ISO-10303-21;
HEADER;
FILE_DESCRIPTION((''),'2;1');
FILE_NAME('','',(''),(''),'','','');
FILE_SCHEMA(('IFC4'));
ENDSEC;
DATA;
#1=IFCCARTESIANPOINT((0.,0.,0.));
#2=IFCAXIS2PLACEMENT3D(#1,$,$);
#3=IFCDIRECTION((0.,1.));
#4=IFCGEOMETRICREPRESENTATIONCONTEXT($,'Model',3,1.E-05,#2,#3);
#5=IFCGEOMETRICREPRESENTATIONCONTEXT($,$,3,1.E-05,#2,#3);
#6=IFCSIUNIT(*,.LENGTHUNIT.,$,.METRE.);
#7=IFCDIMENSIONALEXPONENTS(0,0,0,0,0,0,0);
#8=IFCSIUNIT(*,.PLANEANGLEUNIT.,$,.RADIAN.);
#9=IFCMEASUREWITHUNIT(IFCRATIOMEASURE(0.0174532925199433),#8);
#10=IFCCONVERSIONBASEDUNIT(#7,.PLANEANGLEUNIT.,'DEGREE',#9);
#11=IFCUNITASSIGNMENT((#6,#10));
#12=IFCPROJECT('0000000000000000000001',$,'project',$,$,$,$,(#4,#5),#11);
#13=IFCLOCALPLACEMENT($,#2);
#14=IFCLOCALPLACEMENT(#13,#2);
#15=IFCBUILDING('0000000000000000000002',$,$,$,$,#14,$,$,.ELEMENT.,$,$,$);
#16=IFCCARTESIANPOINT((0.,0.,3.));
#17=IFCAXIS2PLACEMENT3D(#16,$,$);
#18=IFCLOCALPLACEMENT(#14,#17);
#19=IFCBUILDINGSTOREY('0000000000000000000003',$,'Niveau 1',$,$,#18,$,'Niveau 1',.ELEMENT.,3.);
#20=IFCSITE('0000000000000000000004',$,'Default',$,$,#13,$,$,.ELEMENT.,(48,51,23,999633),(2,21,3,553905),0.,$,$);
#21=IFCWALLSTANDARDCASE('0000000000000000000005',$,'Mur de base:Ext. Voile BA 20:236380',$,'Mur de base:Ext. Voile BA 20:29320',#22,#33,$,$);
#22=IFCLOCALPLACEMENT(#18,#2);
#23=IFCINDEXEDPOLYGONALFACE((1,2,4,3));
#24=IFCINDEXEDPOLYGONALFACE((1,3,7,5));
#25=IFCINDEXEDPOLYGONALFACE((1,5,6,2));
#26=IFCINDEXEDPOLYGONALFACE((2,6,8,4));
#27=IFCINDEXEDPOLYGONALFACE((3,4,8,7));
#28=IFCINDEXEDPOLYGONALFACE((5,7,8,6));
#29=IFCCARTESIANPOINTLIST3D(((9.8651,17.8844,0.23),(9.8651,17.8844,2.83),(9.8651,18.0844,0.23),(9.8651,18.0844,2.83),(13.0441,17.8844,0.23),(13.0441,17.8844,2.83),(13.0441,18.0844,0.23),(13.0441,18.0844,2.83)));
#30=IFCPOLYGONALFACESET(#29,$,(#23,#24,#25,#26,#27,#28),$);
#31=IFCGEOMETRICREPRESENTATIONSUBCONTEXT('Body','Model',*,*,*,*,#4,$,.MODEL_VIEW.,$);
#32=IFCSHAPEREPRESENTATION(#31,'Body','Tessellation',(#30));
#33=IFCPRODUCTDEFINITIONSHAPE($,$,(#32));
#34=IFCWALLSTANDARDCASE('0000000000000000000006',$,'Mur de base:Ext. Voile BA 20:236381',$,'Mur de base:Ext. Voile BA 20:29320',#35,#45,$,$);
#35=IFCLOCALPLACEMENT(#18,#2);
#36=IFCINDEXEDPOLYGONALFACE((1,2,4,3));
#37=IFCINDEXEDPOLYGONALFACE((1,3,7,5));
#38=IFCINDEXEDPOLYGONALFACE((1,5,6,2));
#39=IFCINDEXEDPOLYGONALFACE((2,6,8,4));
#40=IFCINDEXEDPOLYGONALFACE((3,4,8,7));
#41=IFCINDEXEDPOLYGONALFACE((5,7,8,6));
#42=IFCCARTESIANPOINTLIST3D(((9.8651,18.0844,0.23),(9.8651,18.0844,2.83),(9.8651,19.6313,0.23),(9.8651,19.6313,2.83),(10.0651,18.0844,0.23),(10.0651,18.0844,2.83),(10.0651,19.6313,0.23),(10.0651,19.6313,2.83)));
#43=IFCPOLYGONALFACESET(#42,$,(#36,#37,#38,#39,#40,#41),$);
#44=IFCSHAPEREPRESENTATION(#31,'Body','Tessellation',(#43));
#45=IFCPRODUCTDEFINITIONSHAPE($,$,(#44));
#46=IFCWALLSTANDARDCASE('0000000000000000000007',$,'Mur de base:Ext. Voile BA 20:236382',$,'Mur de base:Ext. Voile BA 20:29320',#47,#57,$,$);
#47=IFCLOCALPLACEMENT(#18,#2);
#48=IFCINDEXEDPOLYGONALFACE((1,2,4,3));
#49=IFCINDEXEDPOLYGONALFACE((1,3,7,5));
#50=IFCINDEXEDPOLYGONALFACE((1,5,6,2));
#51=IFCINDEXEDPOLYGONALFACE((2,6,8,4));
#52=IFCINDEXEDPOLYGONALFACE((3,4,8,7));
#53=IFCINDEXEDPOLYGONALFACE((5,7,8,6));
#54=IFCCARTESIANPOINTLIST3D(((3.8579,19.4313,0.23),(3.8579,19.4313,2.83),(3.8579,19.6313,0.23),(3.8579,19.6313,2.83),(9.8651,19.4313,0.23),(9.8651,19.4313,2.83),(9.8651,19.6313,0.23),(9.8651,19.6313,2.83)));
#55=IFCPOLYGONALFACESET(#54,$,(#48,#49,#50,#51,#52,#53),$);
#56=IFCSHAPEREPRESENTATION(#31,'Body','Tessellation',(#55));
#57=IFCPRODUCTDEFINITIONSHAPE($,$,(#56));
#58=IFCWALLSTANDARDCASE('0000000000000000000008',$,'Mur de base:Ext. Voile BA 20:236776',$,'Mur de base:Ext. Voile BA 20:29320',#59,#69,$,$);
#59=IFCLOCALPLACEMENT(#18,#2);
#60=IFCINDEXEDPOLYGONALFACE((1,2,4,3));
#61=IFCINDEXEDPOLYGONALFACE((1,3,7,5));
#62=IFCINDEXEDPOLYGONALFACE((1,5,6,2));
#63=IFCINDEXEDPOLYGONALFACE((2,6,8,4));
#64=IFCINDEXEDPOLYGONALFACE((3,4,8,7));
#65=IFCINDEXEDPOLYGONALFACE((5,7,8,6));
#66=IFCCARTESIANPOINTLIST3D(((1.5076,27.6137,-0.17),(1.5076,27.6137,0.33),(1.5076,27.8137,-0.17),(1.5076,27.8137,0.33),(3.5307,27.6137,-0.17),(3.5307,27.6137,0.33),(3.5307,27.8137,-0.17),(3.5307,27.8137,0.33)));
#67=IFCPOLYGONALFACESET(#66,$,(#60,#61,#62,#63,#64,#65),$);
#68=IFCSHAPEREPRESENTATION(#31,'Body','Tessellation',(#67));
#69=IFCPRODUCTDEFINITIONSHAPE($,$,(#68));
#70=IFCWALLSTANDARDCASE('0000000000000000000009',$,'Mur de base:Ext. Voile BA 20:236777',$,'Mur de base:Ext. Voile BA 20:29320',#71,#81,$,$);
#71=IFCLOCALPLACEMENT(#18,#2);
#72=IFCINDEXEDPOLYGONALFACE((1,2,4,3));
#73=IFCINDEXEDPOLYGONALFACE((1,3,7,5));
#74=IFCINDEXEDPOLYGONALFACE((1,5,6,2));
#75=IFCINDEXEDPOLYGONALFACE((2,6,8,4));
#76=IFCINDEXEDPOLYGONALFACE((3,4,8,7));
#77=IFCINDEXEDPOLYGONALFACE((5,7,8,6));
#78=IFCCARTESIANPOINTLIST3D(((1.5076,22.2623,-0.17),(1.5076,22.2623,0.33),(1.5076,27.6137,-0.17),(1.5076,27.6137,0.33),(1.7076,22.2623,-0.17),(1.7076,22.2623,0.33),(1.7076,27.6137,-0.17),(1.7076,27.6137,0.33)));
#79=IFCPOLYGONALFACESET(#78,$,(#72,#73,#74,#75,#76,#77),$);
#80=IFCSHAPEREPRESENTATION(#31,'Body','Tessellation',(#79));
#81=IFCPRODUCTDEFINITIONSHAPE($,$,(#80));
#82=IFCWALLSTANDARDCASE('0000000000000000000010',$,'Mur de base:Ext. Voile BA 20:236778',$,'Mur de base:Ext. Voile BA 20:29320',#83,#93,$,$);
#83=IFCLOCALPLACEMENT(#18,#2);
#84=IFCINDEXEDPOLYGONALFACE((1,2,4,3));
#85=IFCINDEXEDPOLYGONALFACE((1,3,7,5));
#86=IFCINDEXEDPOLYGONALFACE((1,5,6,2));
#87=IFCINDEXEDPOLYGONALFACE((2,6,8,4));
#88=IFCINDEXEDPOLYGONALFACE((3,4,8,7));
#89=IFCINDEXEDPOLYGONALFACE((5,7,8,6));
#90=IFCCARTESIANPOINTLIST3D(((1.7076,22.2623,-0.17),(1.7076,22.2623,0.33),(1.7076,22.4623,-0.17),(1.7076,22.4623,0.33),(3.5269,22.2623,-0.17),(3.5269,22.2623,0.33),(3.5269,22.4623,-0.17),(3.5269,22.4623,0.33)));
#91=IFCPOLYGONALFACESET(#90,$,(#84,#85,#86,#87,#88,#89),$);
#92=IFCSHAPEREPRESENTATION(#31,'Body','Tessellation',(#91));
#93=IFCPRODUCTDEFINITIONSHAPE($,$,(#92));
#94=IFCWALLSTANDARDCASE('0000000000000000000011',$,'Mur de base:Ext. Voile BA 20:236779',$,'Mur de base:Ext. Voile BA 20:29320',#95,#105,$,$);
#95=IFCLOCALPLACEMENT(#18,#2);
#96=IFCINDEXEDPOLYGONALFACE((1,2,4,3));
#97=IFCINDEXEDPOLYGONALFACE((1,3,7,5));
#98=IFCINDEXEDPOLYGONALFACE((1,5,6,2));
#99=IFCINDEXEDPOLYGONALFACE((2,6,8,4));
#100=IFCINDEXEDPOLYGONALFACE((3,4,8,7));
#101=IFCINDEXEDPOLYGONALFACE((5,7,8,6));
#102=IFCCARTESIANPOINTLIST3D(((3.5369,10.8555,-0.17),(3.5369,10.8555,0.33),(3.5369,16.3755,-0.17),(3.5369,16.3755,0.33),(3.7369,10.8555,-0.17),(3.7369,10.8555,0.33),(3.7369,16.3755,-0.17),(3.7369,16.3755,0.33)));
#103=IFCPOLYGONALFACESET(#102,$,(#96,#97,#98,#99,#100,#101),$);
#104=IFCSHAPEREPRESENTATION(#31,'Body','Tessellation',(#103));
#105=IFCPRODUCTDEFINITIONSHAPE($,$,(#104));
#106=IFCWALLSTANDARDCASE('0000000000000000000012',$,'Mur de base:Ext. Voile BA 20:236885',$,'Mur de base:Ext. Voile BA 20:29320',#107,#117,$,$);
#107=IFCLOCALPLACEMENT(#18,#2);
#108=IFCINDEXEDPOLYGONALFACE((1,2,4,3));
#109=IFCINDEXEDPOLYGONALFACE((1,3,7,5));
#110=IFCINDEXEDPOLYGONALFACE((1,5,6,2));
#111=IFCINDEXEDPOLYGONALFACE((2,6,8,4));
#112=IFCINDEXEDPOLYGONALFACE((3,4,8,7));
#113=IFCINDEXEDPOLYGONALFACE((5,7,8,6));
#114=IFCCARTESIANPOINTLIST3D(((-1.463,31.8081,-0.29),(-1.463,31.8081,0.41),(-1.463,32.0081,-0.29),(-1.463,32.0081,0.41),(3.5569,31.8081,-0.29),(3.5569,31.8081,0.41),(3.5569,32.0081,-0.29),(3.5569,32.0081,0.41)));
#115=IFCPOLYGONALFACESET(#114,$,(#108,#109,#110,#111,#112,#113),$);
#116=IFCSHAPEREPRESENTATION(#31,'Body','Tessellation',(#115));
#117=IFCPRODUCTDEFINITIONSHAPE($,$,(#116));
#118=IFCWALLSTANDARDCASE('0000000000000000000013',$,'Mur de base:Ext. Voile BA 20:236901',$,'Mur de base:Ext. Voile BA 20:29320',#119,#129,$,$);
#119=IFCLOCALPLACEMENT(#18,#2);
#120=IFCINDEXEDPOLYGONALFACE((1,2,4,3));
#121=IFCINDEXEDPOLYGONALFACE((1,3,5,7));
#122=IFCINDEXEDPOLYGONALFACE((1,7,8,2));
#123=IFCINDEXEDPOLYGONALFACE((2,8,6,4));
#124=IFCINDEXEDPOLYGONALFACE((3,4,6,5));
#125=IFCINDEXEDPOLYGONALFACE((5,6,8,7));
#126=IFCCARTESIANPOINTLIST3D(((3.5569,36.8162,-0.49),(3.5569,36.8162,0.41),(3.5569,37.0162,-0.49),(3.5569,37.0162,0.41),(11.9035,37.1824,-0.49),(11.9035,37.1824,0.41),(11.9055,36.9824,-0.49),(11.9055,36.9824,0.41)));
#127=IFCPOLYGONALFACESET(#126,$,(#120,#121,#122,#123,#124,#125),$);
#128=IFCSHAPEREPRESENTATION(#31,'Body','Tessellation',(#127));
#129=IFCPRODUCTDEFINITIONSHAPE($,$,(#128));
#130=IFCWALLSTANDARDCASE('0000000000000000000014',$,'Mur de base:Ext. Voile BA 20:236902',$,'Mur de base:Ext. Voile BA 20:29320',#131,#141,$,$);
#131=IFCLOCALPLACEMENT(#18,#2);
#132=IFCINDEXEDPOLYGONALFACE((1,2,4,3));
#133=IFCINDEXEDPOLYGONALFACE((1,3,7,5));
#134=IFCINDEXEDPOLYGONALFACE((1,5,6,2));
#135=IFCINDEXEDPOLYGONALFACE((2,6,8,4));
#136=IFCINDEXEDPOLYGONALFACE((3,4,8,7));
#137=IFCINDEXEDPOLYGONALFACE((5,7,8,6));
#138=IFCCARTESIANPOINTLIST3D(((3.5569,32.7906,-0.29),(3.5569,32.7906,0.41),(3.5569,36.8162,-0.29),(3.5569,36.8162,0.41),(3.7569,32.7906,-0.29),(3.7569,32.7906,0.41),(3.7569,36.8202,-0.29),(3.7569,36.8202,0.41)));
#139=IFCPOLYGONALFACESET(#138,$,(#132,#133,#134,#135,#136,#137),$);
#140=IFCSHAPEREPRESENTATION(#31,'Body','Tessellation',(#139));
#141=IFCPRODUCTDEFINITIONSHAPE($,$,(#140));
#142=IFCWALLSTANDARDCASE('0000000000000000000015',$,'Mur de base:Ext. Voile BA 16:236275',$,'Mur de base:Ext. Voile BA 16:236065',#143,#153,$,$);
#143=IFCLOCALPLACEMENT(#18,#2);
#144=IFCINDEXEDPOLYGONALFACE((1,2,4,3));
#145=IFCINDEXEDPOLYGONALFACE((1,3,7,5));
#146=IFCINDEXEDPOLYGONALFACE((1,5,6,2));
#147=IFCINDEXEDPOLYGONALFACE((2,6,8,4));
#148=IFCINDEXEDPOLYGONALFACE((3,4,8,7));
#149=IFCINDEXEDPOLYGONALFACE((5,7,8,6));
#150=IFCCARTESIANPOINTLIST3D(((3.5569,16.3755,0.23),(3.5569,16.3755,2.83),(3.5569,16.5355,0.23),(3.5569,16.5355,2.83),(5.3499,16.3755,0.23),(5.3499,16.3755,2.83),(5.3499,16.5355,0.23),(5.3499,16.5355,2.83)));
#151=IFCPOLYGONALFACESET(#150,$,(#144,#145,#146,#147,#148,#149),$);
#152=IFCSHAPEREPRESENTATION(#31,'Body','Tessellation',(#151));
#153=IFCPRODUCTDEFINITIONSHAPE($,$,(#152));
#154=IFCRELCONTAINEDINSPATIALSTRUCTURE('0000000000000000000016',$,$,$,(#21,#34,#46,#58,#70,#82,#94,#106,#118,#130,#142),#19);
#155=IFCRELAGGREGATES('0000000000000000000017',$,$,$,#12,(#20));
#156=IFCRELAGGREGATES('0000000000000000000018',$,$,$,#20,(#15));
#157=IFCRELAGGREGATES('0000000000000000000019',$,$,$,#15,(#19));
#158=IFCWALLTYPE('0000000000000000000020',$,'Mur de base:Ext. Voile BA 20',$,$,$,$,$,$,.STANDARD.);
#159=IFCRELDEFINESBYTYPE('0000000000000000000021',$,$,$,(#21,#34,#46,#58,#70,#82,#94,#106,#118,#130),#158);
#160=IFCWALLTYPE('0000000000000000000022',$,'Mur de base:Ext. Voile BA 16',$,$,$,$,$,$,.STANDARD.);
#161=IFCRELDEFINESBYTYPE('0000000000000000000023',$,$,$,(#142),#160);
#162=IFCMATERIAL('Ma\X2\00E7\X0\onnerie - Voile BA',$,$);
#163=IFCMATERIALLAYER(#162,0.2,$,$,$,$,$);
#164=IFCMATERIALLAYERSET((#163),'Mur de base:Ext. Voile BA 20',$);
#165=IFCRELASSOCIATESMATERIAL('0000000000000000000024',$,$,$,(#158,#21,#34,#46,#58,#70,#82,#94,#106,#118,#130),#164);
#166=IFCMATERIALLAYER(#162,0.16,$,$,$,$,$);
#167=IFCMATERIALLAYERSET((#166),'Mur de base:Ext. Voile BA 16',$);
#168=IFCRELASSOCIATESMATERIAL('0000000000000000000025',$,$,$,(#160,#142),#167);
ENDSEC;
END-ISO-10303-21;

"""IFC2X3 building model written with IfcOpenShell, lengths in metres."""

from ifc_helpers import new_model, entity, si_unit, converted_unit, direction, frame, frame_2d, origin, place, context, subcontext, project, spatial, polyline, rectangle, outline, extrude, material, layer, layer_set, layer_usage, type_object, element, save


model = new_model("IFC2X3")

# Units and contexts
model_context = context("Model", 3, precision=1e-05, world=origin(), true_north=direction((0.0, 1.0)))
context_of_model = context(None, 3, precision=1e-05, world=origin(), true_north=direction((0.0, 1.0)))
body_context = subcontext(model_context, "Body", "Model", "MODEL_VIEW")
ifc_project = project(units=[si_unit("LENGTHUNIT", "METRE"), converted_unit("PLANEANGLEUNIT", "DEGREE", entity("IfcRatioMeasure", 0.0174532925199433), si_unit("PLANEANGLEUNIT", "RADIAN"), dimensions=[0, 0, 0, 0, 0, 0, 0])], contexts=[model_context, context_of_model])

# Site, building, storey
site_placement = place(None, origin())
site = spatial("IfcSite", under=ifc_project, at=site_placement, Name="Default", CompositionType="ELEMENT", RefLatitude=(48, 51, 23, 999633), RefLongitude=(2, 21, 3, 553905), RefElevation=0.0)
building_placement = place(site_placement, origin())
building = spatial("IfcBuilding", under=site, at=building_placement, CompositionType="ELEMENT")
storey_placement = place(building_placement, frame((0.0, 0.0, 3.0)))
storey = spatial("IfcBuildingStorey", under=building, at=storey_placement, Name="Niveau 1", LongName="Niveau 1", CompositionType="ELEMENT", Elevation=3.0)

# Shared definitions
ifc_material = material(Name="Maçonnerie - Voile BA")
ifc_layer_1 = layer(ifc_material, 0.2)
ifc_layer_set_1 = layer_set([ifc_layer_1], Name="Mur de base:Ext. Voile BA 20")
wall_type_1 = type_object("IfcWallType", Name="Mur de base:Ext. Voile BA 20", PredefinedType="STANDARD", material=ifc_layer_set_1)

# Walls
ifc_layer_usage_1 = layer_usage(ifc_layer_set_1, "AXIS2", "NEGATIVE", 0.1)
wall_1_placement = place(storey_placement, frame((13.0441, 17.9844, 0.23), z_axis=(0.0, 0.0, 1.0), x_axis=(-1.0, 0.0, 0.0)))
element("IfcWallStandardCase", 1, at=wall_1_placement, inside=storey, type_object=wall_type_1, material=ifc_layer_usage_1, Name="Mur de base:Ext. Voile BA 20:236380", ObjectType="Mur de base:Ext. Voile BA 20:29320", context=body_context, shape_type="SweptSolid", body=[
    extrude(rectangle(XDim=3.179, YDim=0.2, at=frame_2d((1.5895, 0.0), x_axis=(-1.0, 0.0))), origin(), (0.0, 0.0, 1.0), 2.6),
])
ifc_layer_usage_2 = layer_usage(ifc_layer_set_1, "AXIS2", "NEGATIVE", 0.1)
wall_2_placement = place(storey_placement, frame((9.9651, 18.0844, 0.23), z_axis=(0.0, 0.0, 1.0), x_axis=(0.0, 1.0, 0.0)))
element("IfcWallStandardCase", 2, at=wall_2_placement, inside=storey, type_object=wall_type_1, material=ifc_layer_usage_2, Name="Mur de base:Ext. Voile BA 20:236381", ObjectType="Mur de base:Ext. Voile BA 20:29320", context=body_context, shape_type="SweptSolid", body=[
    extrude(rectangle(XDim=1.5469, YDim=0.2, at=frame_2d((0.7735, 0.0), x_axis=(-1.0, 0.0))), origin(), (0.0, 0.0, 1.0), 2.6),
])
ifc_layer_usage_3 = layer_usage(ifc_layer_set_1, "AXIS2", "NEGATIVE", 0.1)
wall_3_placement = place(storey_placement, frame((9.8651, 19.5313, 0.23), z_axis=(0.0, 0.0, 1.0), x_axis=(-1.0, 0.0, 0.0)))
element("IfcWallStandardCase", 3, at=wall_3_placement, inside=storey, type_object=wall_type_1, material=ifc_layer_usage_3, Name="Mur de base:Ext. Voile BA 20:236382", ObjectType="Mur de base:Ext. Voile BA 20:29320", context=body_context, shape_type="SweptSolid", body=[
    extrude(rectangle(XDim=6.0072, YDim=0.2, at=frame_2d((3.0036, 0.0), x_axis=(-1.0, 0.0))), origin(), (0.0, 0.0, 1.0), 2.6),
])
ifc_layer_usage_4 = layer_usage(ifc_layer_set_1, "AXIS2", "POSITIVE", -0.1)
wall_4_placement = place(storey_placement, frame((3.5307, 27.7137, -0.17), z_axis=(0.0, 0.0, 1.0), x_axis=(-1.0, 0.0, 0.0)))
element("IfcWallStandardCase", 4, at=wall_4_placement, inside=storey, type_object=wall_type_1, material=ifc_layer_usage_4, Name="Mur de base:Ext. Voile BA 20:236776", ObjectType="Mur de base:Ext. Voile BA 20:29320", context=body_context, shape_type="SweptSolid", body=[
    extrude(rectangle(XDim=2.0231, YDim=0.2, at=frame_2d((1.0116, 0.0), x_axis=(-1.0, 0.0))), origin(), (0.0, 0.0, 1.0), 0.5),
])
ifc_layer_usage_5 = layer_usage(ifc_layer_set_1, "AXIS2", "POSITIVE", -0.1)
wall_5_placement = place(storey_placement, frame((1.6076, 27.6137, -0.17), z_axis=(0.0, 0.0, 1.0), x_axis=(0.0, -1.0, 0.0)))
element("IfcWallStandardCase", 5, at=wall_5_placement, inside=storey, type_object=wall_type_1, material=ifc_layer_usage_5, Name="Mur de base:Ext. Voile BA 20:236777", ObjectType="Mur de base:Ext. Voile BA 20:29320", context=body_context, shape_type="SweptSolid", body=[
    extrude(rectangle(XDim=5.3514, YDim=0.2, at=frame_2d((2.6757, 0.0), x_axis=(-1.0, 0.0))), origin(), (0.0, 0.0, 1.0), 0.5),
])
ifc_layer_usage_6 = layer_usage(ifc_layer_set_1, "AXIS2", "POSITIVE", -0.1)
wall_6_placement = place(storey_placement, frame((1.7076, 22.3623, -0.17)))
element("IfcWallStandardCase", 6, at=wall_6_placement, inside=storey, type_object=wall_type_1, material=ifc_layer_usage_6, Name="Mur de base:Ext. Voile BA 20:236778", ObjectType="Mur de base:Ext. Voile BA 20:29320", context=body_context, shape_type="SweptSolid", body=[
    extrude(rectangle(XDim=1.8193, YDim=0.2, at=frame_2d((0.9097, 0.0), x_axis=(-1.0, 0.0))), origin(), (0.0, 0.0, 1.0), 0.5),
])
ifc_layer_usage_7 = layer_usage(ifc_layer_set_1, "AXIS2", "NEGATIVE", 0.1)
wall_7_placement = place(storey_placement, frame((3.6369, 16.3755, -0.17), z_axis=(0.0, 0.0, 1.0), x_axis=(0.0, -1.0, 0.0)))
element("IfcWallStandardCase", 7, at=wall_7_placement, inside=storey, type_object=wall_type_1, material=ifc_layer_usage_7, Name="Mur de base:Ext. Voile BA 20:236779", ObjectType="Mur de base:Ext. Voile BA 20:29320", context=body_context, shape_type="SweptSolid", body=[
    extrude(rectangle(XDim=5.52, YDim=0.2, at=frame_2d((2.76, 0.0), x_axis=(-1.0, 0.0))), origin(), (0.0, 0.0, 1.0), 0.5),
])
ifc_layer_usage_8 = layer_usage(ifc_layer_set_1, "AXIS2", "NEGATIVE", 0.1)
wall_8_placement = place(storey_placement, frame((-1.463, 31.9081, -0.29)))
element("IfcWallStandardCase", 8, at=wall_8_placement, inside=storey, type_object=wall_type_1, material=ifc_layer_usage_8, Name="Mur de base:Ext. Voile BA 20:236885", ObjectType="Mur de base:Ext. Voile BA 20:29320", context=body_context, shape_type="SweptSolid", body=[
    extrude(rectangle(XDim=5.0199, YDim=0.2, at=frame_2d((2.51, 0.0), x_axis=(-1.0, 0.0))), origin(), (0.0, 0.0, 1.0), 0.7),
])
ifc_layer_usage_9 = layer_usage(ifc_layer_set_1, "AXIS2", "POSITIVE", -0.1)
wall_9_placement = place(storey_placement, frame((11.9055, 37.0824, -0.49), z_axis=(0.0, 0.0, 1.0), x_axis=(-0.999802, -0.019906, 0.0)))
element("IfcWallStandardCase", 9, at=wall_9_placement, inside=storey, type_object=wall_type_1, material=ifc_layer_usage_9, Name="Mur de base:Ext. Voile BA 20:236901", ObjectType="Mur de base:Ext. Voile BA 20:29320", context=body_context, shape_type="SweptSolid", body=[
    extrude(outline(polyline([(8.3482, -0.1), (8.3522, 0.1), (0.002, 0.1), (0.0, -0.1), (8.3482, -0.1)])), origin(), (0.0, 0.0, 1.0), 0.9),
])
ifc_layer_usage_10 = layer_usage(ifc_layer_set_1, "AXIS2", "NEGATIVE", 0.1)
wall_10_placement = place(storey_placement, frame((3.6569, 32.7906, -0.29), z_axis=(0.0, 0.0, 1.0), x_axis=(0.0, 1.0, 0.0)))
element("IfcWallStandardCase", 10, at=wall_10_placement, inside=storey, type_object=wall_type_1, material=ifc_layer_usage_10, Name="Mur de base:Ext. Voile BA 20:236902", ObjectType="Mur de base:Ext. Voile BA 20:29320", context=body_context, shape_type="SweptSolid", body=[
    extrude(outline(polyline([(4.0295, -0.1), (4.0255, 0.1), (0.0, 0.1), (0.0, -0.1), (4.0295, -0.1)])), origin(), (0.0, 0.0, 1.0), 0.7),
])
ifc_layer_2 = layer(ifc_material, 0.16)
ifc_layer_set_2 = layer_set([ifc_layer_2], Name="Mur de base:Ext. Voile BA 16")
ifc_layer_usage_11 = layer_usage(ifc_layer_set_2, "AXIS2", "NEGATIVE", 0.08)
wall_type_2 = type_object("IfcWallType", Name="Mur de base:Ext. Voile BA 16", PredefinedType="STANDARD", material=ifc_layer_set_2)
wall_11_placement = place(storey_placement, frame((5.3499, 16.4555, 0.23), z_axis=(0.0, 0.0, 1.0), x_axis=(-1.0, 0.0, 0.0)))
element("IfcWallStandardCase", 11, at=wall_11_placement, inside=storey, type_object=wall_type_2, material=ifc_layer_usage_11, Name="Mur de base:Ext. Voile BA 16:236275", ObjectType="Mur de base:Ext. Voile BA 16:236065", context=body_context, shape_type="SweptSolid", body=[
    extrude(rectangle(XDim=1.793, YDim=0.16, at=frame_2d((0.8965, 0.0), x_axis=(-1.0, 0.0))), origin(), (0.0, 0.0, 1.0), 2.6),
])

save(model, "model.ifc")
